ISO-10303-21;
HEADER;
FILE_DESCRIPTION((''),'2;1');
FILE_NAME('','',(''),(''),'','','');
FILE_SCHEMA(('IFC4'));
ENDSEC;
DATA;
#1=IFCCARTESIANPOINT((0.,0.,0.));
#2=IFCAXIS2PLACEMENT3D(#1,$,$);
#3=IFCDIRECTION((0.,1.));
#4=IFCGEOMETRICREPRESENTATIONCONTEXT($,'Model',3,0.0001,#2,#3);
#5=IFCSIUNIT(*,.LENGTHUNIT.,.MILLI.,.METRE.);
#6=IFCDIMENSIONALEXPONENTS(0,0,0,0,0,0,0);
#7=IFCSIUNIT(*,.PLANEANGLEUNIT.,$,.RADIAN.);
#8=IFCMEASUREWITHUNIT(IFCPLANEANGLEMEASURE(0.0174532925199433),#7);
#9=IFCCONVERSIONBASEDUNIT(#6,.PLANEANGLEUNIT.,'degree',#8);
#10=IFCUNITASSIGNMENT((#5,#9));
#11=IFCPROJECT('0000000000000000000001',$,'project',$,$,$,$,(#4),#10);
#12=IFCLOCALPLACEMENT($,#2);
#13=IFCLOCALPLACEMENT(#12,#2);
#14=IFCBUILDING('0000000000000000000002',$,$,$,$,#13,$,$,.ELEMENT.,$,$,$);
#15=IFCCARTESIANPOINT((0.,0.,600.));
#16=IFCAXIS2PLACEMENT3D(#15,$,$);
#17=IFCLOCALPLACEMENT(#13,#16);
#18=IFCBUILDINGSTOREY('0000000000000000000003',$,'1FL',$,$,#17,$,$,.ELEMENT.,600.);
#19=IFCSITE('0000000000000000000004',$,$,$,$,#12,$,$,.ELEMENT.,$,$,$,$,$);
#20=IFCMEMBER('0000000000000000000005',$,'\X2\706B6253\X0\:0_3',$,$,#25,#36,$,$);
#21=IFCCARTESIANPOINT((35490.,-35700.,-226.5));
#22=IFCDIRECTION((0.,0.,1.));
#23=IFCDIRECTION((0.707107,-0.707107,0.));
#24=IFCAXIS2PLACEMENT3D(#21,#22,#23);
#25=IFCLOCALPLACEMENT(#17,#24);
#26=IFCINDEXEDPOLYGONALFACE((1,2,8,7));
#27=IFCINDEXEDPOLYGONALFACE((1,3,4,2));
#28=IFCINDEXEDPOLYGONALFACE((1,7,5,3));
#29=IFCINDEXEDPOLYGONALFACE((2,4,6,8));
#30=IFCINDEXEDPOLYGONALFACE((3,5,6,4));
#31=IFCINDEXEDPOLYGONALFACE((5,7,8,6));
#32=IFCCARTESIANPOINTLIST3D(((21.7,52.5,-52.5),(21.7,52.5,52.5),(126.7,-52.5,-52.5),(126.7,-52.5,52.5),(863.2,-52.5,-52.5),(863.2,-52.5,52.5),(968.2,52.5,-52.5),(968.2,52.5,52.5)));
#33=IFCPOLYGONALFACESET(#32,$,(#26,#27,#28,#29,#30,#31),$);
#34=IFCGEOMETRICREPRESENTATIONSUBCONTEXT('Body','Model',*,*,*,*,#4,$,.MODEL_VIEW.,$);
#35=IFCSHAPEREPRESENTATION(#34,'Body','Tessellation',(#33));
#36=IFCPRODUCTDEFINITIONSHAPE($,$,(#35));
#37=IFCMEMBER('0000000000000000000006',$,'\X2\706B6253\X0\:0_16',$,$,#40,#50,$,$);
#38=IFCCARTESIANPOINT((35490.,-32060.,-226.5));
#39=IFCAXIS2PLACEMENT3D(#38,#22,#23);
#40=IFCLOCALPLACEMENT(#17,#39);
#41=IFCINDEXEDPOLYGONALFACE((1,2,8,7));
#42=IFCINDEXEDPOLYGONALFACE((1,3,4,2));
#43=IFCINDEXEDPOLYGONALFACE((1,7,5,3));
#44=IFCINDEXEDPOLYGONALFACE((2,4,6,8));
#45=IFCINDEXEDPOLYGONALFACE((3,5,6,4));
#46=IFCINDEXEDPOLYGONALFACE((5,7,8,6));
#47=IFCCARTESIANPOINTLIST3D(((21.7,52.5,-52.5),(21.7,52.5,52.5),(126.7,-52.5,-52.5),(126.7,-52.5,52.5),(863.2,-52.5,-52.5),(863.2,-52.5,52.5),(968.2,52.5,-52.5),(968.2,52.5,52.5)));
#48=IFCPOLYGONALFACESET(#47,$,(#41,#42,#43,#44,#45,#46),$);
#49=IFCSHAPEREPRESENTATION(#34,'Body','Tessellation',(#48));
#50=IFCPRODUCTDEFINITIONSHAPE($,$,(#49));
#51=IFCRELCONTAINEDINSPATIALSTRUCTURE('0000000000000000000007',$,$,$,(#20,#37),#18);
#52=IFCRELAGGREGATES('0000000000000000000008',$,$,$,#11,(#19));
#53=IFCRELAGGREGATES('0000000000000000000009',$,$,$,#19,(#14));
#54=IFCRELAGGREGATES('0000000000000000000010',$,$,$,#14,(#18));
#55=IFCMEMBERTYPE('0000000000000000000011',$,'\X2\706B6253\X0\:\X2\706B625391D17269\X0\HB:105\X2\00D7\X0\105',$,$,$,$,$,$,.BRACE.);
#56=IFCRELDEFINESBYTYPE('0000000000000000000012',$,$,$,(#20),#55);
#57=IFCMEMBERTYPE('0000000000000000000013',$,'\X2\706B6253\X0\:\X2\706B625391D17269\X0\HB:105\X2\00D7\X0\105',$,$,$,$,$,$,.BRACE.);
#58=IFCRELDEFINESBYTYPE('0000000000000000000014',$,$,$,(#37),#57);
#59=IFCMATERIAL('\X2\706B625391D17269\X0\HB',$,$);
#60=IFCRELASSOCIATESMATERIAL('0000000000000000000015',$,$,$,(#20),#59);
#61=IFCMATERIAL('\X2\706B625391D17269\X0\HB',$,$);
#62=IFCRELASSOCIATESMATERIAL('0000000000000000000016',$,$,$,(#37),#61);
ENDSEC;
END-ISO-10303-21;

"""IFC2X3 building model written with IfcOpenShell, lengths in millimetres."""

from ifc_helpers import new_model, entity, si_unit, converted_unit, direction, frame, origin, place, context, subcontext, project, spatial, polyline, outline, extrude, material, type_object, element, save


model = new_model("IFC2X3")

# Units and contexts
model_context = context("Model", 3, precision=0.0001, world=origin(), true_north=direction((0.0, 1.0)))
body_context = subcontext(model_context, "Body", "Model", "MODEL_VIEW")
ifc_project = project(units=[si_unit("LENGTHUNIT", "METRE", prefix="MILLI"), converted_unit("PLANEANGLEUNIT", "degree", entity("IfcPlaneAngleMeasure", 0.0174532925199433), si_unit("PLANEANGLEUNIT", "RADIAN"), dimensions=[0, 0, 0, 0, 0, 0, 0])], contexts=[model_context])

# Site, building, storey
site_placement = place(None, origin())
site = spatial("IfcSite", under=ifc_project, at=site_placement, CompositionType="ELEMENT")
building_placement = place(site_placement, origin())
building = spatial("IfcBuilding", under=site, at=building_placement, CompositionType="ELEMENT")
storey_placement = place(building_placement, frame((0.0, 0.0, 600.0)))
storey = spatial("IfcBuildingStorey", under=building, at=storey_placement, Name="1FL", CompositionType="ELEMENT", Elevation=600.0)

# Members
ifc_material_1 = material(Name="火打金物HB")
member_type_1 = type_object("IfcMemberType", Name="火打:火打金物HB:105×105", PredefinedType="BRACE")
member_1_placement = place(storey_placement, frame((35490.0, -35700.0, -226.5), z_axis=(0.0, 0.0, 1.0), x_axis=(0.707107, -0.707107, 0.0)))
element("IfcMember", 1, at=member_1_placement, inside=storey, type_object=member_type_1, material=ifc_material_1, Name="火打:0_3", context=body_context, shape_type="SweptSolid", body=[
    extrude(outline(polyline([(126.7, -52.5, 0.0), (21.7, 52.5, 0.0), (968.2, 52.5, 0.0), (863.2, -52.5, 0.0), (126.7, -52.5, 0.0)])), frame((0.0, 0.0, -52.5), z_axis=(0.0, 0.0, 1.0), x_axis=(1.0, 0.0, 0.0)), (0.0, 0.0, 1.0), 105.0),
])
ifc_material_2 = material(Name="火打金物HB")
member_type_2 = type_object("IfcMemberType", Name="火打:火打金物HB:105×105", PredefinedType="BRACE")
member_2_placement = place(storey_placement, frame((35490.0, -32060.0, -226.5), z_axis=(0.0, 0.0, 1.0), x_axis=(0.707107, -0.707107, 0.0)))
element("IfcMember", 2, at=member_2_placement, inside=storey, type_object=member_type_2, material=ifc_material_2, Name="火打:0_16", context=body_context, shape_type="SweptSolid", body=[
    extrude(outline(polyline([(126.7, -52.5, 0.0), (21.7, 52.5, 0.0), (968.2, 52.5, 0.0), (863.2, -52.5, 0.0), (126.7, -52.5, 0.0)])), frame((0.0, 0.0, -52.5), z_axis=(0.0, 0.0, 1.0), x_axis=(1.0, 0.0, 0.0)), (0.0, 0.0, 1.0), 105.0),
])

save(model, "model.ifc")
